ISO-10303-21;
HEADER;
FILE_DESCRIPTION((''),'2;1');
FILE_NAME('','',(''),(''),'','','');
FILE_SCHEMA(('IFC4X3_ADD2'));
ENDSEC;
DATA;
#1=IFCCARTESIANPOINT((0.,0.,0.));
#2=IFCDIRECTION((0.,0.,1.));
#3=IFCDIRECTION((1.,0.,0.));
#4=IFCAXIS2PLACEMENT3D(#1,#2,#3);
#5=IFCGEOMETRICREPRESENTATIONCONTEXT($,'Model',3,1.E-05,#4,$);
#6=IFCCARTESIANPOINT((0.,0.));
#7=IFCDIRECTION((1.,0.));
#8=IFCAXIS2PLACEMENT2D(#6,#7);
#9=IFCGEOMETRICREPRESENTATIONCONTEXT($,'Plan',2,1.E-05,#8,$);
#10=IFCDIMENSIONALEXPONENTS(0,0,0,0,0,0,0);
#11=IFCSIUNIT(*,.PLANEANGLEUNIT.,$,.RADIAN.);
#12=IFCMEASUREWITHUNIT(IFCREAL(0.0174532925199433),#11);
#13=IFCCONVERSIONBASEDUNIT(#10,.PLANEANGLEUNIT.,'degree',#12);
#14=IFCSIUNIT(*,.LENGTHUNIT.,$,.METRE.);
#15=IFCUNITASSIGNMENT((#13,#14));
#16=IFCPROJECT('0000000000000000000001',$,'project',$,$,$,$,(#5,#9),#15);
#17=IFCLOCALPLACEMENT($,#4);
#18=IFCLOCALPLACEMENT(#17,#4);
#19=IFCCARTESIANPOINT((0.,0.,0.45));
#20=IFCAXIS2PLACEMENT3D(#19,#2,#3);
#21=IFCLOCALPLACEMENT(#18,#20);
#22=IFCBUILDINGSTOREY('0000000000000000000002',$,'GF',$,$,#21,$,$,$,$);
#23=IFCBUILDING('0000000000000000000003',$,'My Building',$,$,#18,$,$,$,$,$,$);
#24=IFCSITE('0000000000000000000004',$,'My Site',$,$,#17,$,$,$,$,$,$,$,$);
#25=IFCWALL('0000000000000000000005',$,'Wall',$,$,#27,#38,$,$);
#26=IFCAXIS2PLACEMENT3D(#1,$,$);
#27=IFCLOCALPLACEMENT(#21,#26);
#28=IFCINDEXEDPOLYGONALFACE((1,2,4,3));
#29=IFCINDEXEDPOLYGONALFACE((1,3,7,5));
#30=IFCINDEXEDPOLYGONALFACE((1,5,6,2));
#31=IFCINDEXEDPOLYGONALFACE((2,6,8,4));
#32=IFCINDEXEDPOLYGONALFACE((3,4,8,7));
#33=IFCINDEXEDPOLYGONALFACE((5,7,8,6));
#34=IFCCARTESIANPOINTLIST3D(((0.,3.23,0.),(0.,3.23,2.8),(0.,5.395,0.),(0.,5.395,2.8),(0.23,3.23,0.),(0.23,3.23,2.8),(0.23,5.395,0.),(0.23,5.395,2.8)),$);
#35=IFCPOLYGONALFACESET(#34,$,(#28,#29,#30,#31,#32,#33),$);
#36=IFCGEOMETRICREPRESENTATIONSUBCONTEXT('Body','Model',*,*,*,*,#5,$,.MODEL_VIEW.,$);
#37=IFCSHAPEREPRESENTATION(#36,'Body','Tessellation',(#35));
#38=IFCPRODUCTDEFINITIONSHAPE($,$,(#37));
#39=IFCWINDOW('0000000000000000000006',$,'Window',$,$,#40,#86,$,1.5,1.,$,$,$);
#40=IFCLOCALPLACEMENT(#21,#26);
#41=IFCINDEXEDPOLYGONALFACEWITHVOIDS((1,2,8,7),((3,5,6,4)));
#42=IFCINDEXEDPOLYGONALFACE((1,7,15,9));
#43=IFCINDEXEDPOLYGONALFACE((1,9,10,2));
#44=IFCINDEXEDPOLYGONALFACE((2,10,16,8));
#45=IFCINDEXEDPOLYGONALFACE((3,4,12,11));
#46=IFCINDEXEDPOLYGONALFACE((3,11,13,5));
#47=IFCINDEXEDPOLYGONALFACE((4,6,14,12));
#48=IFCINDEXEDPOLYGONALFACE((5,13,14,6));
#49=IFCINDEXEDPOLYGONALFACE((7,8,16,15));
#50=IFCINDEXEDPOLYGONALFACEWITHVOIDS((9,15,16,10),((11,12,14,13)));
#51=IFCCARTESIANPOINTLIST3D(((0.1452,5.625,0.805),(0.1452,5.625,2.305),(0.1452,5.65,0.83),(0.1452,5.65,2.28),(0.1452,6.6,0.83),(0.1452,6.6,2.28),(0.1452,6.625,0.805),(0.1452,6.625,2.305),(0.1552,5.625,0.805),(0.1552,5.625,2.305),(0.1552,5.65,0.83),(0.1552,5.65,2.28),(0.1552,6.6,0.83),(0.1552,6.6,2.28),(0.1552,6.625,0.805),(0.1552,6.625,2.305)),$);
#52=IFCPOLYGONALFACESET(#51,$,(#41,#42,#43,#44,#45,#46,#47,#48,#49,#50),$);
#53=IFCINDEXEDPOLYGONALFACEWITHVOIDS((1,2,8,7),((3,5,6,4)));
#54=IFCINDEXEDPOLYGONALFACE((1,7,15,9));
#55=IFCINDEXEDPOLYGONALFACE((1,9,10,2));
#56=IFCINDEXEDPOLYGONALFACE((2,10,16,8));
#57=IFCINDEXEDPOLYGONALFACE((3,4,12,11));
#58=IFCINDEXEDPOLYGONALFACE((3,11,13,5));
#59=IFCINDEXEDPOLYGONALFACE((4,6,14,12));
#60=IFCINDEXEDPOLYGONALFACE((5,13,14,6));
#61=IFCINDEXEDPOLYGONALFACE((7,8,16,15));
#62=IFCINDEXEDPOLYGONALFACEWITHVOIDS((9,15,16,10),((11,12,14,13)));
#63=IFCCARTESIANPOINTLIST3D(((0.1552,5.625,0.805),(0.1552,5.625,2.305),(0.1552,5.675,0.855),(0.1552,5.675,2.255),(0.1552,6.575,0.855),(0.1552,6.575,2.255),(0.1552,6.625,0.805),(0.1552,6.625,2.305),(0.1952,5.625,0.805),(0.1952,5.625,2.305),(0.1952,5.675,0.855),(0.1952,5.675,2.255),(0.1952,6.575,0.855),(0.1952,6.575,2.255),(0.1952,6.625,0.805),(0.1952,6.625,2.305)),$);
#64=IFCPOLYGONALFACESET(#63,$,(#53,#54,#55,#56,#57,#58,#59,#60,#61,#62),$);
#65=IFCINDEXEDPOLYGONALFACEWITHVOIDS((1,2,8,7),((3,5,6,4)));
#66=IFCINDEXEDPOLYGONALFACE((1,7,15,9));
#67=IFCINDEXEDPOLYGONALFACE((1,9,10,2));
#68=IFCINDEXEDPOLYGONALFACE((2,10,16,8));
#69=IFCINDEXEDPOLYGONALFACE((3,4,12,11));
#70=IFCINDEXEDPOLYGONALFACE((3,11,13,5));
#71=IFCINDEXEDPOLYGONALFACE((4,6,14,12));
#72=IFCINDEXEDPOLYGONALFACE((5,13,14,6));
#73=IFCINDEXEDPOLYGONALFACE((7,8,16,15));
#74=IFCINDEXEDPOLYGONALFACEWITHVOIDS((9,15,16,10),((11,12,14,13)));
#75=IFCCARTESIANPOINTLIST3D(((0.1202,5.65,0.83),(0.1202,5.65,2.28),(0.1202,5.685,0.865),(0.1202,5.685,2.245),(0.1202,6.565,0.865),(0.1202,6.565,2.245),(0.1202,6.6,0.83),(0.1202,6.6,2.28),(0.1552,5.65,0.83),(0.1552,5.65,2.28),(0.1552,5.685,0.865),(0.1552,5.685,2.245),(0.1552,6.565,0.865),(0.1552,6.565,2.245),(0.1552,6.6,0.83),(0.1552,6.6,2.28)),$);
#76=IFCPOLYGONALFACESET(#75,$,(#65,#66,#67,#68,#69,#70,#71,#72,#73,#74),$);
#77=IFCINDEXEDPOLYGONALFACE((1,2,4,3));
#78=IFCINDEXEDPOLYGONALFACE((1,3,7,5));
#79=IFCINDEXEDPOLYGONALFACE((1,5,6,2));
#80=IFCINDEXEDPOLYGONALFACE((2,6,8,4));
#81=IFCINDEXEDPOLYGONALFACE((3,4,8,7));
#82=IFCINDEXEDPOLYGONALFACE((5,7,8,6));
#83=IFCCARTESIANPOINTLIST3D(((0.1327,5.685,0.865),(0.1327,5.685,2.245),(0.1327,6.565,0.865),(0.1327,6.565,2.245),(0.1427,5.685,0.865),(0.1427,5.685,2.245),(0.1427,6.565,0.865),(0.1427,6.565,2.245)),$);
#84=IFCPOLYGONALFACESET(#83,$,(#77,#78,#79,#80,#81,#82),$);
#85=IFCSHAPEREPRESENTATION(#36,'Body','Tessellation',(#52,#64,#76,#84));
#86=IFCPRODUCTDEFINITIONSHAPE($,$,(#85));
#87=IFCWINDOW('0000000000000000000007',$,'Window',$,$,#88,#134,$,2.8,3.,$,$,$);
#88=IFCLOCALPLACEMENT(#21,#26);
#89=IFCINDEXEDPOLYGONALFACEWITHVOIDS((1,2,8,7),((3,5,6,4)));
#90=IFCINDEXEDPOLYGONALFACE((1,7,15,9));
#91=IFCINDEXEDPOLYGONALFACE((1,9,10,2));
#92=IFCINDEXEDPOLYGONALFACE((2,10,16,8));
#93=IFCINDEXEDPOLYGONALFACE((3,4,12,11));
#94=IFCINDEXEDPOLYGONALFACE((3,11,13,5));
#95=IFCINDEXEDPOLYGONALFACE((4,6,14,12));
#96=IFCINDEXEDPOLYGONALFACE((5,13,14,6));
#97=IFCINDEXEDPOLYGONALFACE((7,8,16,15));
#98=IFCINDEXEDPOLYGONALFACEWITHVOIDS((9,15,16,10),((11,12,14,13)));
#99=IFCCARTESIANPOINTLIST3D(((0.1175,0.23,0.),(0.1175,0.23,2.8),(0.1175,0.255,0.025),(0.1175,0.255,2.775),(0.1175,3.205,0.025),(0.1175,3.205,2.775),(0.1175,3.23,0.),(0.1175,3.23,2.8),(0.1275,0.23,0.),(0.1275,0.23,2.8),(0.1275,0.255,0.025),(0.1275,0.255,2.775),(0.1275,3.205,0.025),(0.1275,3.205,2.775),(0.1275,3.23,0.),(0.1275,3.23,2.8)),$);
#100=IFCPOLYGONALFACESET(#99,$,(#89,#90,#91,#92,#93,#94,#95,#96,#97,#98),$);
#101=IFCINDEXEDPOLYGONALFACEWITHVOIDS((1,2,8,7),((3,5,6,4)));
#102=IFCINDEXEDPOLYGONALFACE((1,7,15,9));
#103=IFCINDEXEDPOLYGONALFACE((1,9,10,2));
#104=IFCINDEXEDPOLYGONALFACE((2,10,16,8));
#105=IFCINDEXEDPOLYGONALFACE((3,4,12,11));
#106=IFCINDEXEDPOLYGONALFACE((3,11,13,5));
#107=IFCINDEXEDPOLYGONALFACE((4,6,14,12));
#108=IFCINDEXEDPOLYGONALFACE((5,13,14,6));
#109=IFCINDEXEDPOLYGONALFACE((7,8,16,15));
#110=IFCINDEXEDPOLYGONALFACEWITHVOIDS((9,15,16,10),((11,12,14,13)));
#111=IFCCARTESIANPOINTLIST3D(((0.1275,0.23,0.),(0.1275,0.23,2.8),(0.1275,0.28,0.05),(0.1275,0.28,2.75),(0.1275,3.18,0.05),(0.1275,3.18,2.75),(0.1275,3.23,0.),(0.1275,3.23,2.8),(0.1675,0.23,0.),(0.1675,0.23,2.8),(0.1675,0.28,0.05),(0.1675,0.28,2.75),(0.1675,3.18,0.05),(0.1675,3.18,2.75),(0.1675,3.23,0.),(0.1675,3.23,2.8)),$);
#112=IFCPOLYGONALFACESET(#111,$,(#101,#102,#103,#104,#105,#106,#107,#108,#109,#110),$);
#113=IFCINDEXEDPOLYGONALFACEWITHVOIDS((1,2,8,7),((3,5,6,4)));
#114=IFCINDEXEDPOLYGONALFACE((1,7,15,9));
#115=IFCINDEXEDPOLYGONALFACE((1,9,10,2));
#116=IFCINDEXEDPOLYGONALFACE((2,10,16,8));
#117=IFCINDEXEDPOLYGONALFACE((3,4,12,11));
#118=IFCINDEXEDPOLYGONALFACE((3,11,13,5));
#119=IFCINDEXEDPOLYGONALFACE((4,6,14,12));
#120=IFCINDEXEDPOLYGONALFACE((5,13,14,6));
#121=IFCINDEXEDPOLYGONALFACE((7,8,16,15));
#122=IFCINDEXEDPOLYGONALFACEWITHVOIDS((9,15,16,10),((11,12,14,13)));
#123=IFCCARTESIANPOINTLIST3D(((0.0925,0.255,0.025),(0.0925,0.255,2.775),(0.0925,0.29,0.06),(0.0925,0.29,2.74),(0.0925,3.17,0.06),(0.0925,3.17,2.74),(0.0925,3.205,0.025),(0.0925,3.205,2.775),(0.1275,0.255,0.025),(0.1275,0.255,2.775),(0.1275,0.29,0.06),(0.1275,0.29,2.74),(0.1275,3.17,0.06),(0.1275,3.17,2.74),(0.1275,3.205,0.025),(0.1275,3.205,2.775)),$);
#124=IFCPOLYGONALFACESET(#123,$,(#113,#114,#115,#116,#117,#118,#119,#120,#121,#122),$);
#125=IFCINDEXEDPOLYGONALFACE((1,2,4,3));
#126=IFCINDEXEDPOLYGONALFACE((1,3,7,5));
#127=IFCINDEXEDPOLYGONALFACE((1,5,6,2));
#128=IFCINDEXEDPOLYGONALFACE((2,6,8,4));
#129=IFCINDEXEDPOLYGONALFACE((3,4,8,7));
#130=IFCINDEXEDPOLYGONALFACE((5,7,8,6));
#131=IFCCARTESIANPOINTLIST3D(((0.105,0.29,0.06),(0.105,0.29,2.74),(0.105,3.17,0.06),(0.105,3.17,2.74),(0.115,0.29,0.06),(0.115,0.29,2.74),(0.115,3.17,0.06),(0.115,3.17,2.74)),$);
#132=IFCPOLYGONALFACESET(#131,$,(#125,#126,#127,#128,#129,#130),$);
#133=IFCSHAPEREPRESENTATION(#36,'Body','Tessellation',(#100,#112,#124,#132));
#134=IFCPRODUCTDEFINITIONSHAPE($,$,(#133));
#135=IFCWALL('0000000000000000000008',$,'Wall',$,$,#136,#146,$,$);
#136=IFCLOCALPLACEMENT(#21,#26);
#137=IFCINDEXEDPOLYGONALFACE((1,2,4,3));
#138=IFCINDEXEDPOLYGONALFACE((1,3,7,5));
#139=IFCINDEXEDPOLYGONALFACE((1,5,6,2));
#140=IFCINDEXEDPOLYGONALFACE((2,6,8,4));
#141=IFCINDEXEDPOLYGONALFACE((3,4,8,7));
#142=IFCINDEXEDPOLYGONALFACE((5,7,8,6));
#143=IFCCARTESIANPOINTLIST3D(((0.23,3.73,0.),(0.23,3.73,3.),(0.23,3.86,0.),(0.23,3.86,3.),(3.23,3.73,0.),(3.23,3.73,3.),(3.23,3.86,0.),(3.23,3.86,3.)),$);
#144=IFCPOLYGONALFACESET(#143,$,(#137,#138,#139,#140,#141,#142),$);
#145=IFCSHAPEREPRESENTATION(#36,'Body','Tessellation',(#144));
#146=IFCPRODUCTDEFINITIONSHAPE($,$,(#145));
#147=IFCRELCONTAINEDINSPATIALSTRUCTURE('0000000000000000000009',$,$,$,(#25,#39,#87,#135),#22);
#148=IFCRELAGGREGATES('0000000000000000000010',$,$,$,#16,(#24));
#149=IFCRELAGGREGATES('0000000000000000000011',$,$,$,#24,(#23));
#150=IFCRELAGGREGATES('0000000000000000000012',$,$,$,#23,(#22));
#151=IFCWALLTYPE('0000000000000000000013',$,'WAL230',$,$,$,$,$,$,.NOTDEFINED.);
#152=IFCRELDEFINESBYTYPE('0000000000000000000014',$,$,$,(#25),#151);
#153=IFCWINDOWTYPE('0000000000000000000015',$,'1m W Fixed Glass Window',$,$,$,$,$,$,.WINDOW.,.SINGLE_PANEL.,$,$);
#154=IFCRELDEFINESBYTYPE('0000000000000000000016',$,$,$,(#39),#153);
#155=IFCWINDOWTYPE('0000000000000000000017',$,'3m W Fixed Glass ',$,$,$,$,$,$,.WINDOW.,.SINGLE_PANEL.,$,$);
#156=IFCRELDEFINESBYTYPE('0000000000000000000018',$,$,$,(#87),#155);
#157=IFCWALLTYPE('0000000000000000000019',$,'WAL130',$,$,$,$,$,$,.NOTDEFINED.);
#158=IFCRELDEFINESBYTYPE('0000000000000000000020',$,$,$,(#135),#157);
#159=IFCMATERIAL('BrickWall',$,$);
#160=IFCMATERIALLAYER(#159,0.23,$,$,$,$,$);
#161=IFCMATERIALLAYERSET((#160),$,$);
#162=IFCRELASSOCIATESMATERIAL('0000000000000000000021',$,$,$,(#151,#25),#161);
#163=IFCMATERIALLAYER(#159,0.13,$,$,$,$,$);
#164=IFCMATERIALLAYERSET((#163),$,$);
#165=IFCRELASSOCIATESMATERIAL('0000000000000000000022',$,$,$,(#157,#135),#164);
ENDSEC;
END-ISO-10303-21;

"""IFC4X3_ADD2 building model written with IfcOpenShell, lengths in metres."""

from ifc_helpers import new_model, entity, si_unit, converted_unit, frame, origin_with_axes, origin_2d_with_axis, place, context, subcontext, project, spatial, line, indexed_curve, outline, extrude, shape, source, transform, mapped, material, layer, layer_set, layer_usage, type_object, type_shapes, element, fill, save


model = new_model("IFC4X3_ADD2")

# Units and contexts
model_context = context("Model", 3, precision=1e-05, world=origin_with_axes())
plan_context = context("Plan", 2, precision=1e-05, world=origin_2d_with_axis())
body_context_1 = subcontext(model_context, "Body", "Model", "MODEL_VIEW")
body_context_2 = subcontext(plan_context, "Body", "Plan", "PLAN_VIEW")
ifc_project = project(units=[converted_unit("PLANEANGLEUNIT", "degree", entity("IfcReal", 0.0174532925199433), si_unit("PLANEANGLEUNIT", "RADIAN"), dimensions=[0, 0, 0, 0, 0, 0, 0]), si_unit("LENGTHUNIT", "METRE")], contexts=[model_context, plan_context])

# Site, building, storey
site_placement = place(None, origin_with_axes())
site = spatial("IfcSite", under=ifc_project, at=site_placement, Name="My Site")
building_placement = place(site_placement, origin_with_axes())
building = spatial("IfcBuilding", under=site, at=building_placement, Name="My Building")
storey_placement = place(building_placement, frame((0.0, 0.0, 0.45), z_axis=(0.0, 0.0, 1.0), x_axis=(1.0, 0.0, 0.0)))
storey = spatial("IfcBuildingStorey", under=building, at=storey_placement, Name="GF")

# Shared definitions
ifc_material_1 = material(Name="BrickWall")

# Shared definitions
ifc_layer_1 = layer(ifc_material_1, 0.23)
ifc_layer_set_1 = layer_set([ifc_layer_1])
wall_type_1 = type_object("IfcWallType", Name="WAL230", PredefinedType="NOTDEFINED", material=ifc_layer_set_1)

# Wall, openings, windows
ifc_layer_usage_1 = layer_usage(ifc_layer_set_1, "AXIS2", "POSITIVE", 0.0)
wall_1_placement = place(storey_placement, frame((0.23, 3.23, 0.0), z_axis=(0.0, 0.0, 1.0), x_axis=(0.0, 1.0, 0.0)))
wall_1 = element("IfcWall", 1, at=wall_1_placement, inside=storey, type_object=wall_type_1, material=ifc_layer_usage_1, Name="Wall", context=body_context_1, shape_type="SweptSolid", body=[
    extrude(outline(indexed_curve([(0.0, 0.0), (0.0, 0.23), (2.165, 0.23), (2.165, 0.0), (0.0, 0.0)], self_intersect=False)), origin_with_axes(), (0.0, 0.0, 1.0), 2.8),
])
shared_shape_1 = source(origin_with_axes(), body_context_1, "Body", "SweptSolid", [
    extrude(outline(indexed_curve([(0.0, 0.0), (1.0, 0.0), (1.0, 1.5), (0.0, 1.5)], segments=[line(1, 2, 3, 4, 1)])), frame((0.0, -0.6, 0.0), z_axis=(0.0, -1.0, 0.0), x_axis=(1.0, 0.0, 0.0)), (0.0, 0.0, -1.0), 1.2),
])
opening_1_placement = place(wall_1_placement, frame((2.395, -0.0152, 0.805), z_axis=(0.0, 0.0, 1.0), x_axis=(1.0, 0.0, 0.0)))
opening_1 = element("IfcOpeningElement", 2, at=opening_1_placement, cuts=wall_1, PredefinedType="OPENING", context=body_context_1, shape_type="MappedRepresentation", body=[
    mapped(shared_shape_1, transform((0.0, 0.0, 0.0), x_axis=(1.0, 0.0, 0.0), y_axis=(0.0, 1.0, 0.0), z_axis=(0.0, 0.0, 1.0), scale=1.0)),
])
shared_shape_2 = source(origin_with_axes(), body_context_1, "Body", "SweptSolid", [
    extrude(outline(indexed_curve([(0.0, 0.0), (3.0, 0.0), (3.0, 2.8), (0.0, 2.8)], segments=[line(1, 2, 3, 4, 1)])), frame((0.0, -0.6, 0.0), z_axis=(0.0, -1.0, 0.0), x_axis=(1.0, 0.0, 0.0)), (0.0, 0.0, -1.0), 1.2),
])
opening_2_placement = place(wall_1_placement, frame((-3.0, 0.0125, 0.0), z_axis=(0.0, 0.0, 1.0), x_axis=(1.0, 0.0, 0.0)))
opening_2 = element("IfcOpeningElement", 3, at=opening_2_placement, cuts=wall_1, PredefinedType="OPENING", context=body_context_1, shape_type="MappedRepresentation", body=[
    mapped(shared_shape_2, transform((0.0, 0.0, 0.0), x_axis=(1.0, 0.0, 0.0), y_axis=(0.0, 1.0, 0.0), z_axis=(0.0, 0.0, 1.0), scale=1.0)),
])
window_type_1 = type_object("IfcWindowType", Name="1m W Fixed Glass Window", PartitioningType="SINGLE_PANEL", PredefinedType="WINDOW")
shared_shape_3 = source(origin_with_axes(), body_context_1, "Body", "SweptSolid", [
    extrude(outline(indexed_curve([(0.0, 0.0), (1.0, 0.0), (1.0, 1.5), (0.0, 1.5)], segments=[line(1, 2, 3, 4, 1)]), holes=[indexed_curve([(0.025, 0.025), (0.975, 0.025), (0.975, 1.475), (0.025, 1.475)], segments=[line(1, 2, 3, 4, 1)])]), frame((0.0, 0.09, 0.0), z_axis=(0.0, -1.0, 0.0), x_axis=(1.0, 0.0, 0.0)), (0.0, 0.0, -1.0), 0.01),
    extrude(outline(indexed_curve([(0.0, 0.0), (1.0, 0.0), (1.0, 1.5), (0.0, 1.5)], segments=[line(1, 2, 3, 4, 1)]), holes=[indexed_curve([(0.05, 0.05), (0.95, 0.05), (0.95, 1.45), (0.05, 1.45)], segments=[line(1, 2, 3, 4, 1)])]), frame((0.0, 0.05, 0.0), z_axis=(0.0, -1.0, 0.0), x_axis=(1.0, 0.0, 0.0)), (0.0, 0.0, -1.0), 0.04),
    extrude(outline(indexed_curve([(0.0, 0.0), (0.95, 0.0), (0.95, 1.45), (0.0, 1.45)], segments=[line(1, 2, 3, 4, 1)]), holes=[indexed_curve([(0.035, 0.035), (0.915, 0.035), (0.915, 1.415), (0.035, 1.415)], segments=[line(1, 2, 3, 4, 1)])]), frame((0.025, 0.09, 0.025), z_axis=(0.0, -1.0, 0.0), x_axis=(1.0, 0.0, 0.0)), (0.0, 0.0, -1.0), 0.035),
    extrude(outline(indexed_curve([(0.035, 0.035), (0.915, 0.035), (0.915, 1.415), (0.035, 1.415)], segments=[line(1, 2, 3, 4, 1)])), frame((0.025, 0.1025, 0.025), z_axis=(0.0, -1.0, 0.0), x_axis=(1.0, 0.0, 0.0)), (0.0, 0.0, -1.0), 0.01),
])
shared_shape_4 = source(origin_with_axes(), body_context_2, "Body", "Curve2D", [
    entity("IfcIndexedPolyCurve", entity("IfcCartesianPointList2D", [[0.05, 0.05], [0.95, 0.05]])),
    entity("IfcIndexedPolyCurve", entity("IfcCartesianPointList2D", [[0.0, 0.1], [0.025, 0.1], [0.025, 0.09], [0.05, 0.09], [0.05, 0.05], [0.0, 0.05]]), [entity("IfcLineIndex", [1, 2, 3, 4, 5, 6, 1])]),
    entity("IfcIndexedPolyCurve", entity("IfcCartesianPointList2D", [[1.0, 0.1], [0.975, 0.1], [0.975, 0.09], [0.95, 0.09], [0.95, 0.05], [1.0, 0.05]]), [entity("IfcLineIndex", [1, 2, 3, 4, 5, 6, 1])]),
    entity("IfcIndexedPolyCurve", entity("IfcCartesianPointList2D", [[0.025, 0.09], [0.06, 0.09], [0.06, 0.125], [0.025, 0.125]]), [entity("IfcLineIndex", [1, 2, 3, 4, 1])]),
    entity("IfcIndexedPolyCurve", entity("IfcCartesianPointList2D", [[0.975, 0.09], [0.94, 0.09], [0.94, 0.125], [0.975, 0.125]]), [entity("IfcLineIndex", [1, 2, 3, 4, 1])]),
    entity("IfcIndexedPolyCurve", entity("IfcCartesianPointList2D", [[0.06, 0.09], [0.94, 0.09]])),
    entity("IfcIndexedPolyCurve", entity("IfcCartesianPointList2D", [[0.06, 0.125], [0.94, 0.125]])),
    entity("IfcIndexedPolyCurve", entity("IfcCartesianPointList2D", [[0.06, 0.1075], [0.94, 0.1075]])),
])
type_shapes(window_type_1, [shared_shape_3, shared_shape_4])
window_1_placement = place(opening_1_placement, origin_with_axes())
window_1 = element("IfcWindow", 4, at=window_1_placement, inside=storey, type_object=window_type_1, Name="Window", OverallHeight=1.5, OverallWidth=1.0, shapes=[
    shape(body_context_1, "Body", "MappedRepresentation", [mapped(shared_shape_3, transform((0.0, 0.0, 0.0), x_axis=(1.0, 0.0, 0.0), y_axis=(0.0, 1.0, 0.0), z_axis=(0.0, 0.0, 1.0), scale=1.0))]),
    shape(body_context_2, "Body", "MappedRepresentation", [mapped(shared_shape_4, transform((0.0, 0.0, 0.0), x_axis=(1.0, 0.0, 0.0), y_axis=(0.0, 1.0, 0.0), z_axis=(0.0, 0.0, 1.0), scale=1.0))]),
])
fill(opening_1, window_1)
window_type_2 = type_object("IfcWindowType", Name="3m W Fixed Glass ", PartitioningType="SINGLE_PANEL", PredefinedType="WINDOW")
shared_shape_5 = source(origin_with_axes(), body_context_1, "Body", "SweptSolid", [
    extrude(outline(indexed_curve([(0.0, 0.0), (3.0, 0.0), (3.0, 2.8), (0.0, 2.8)], segments=[line(1, 2, 3, 4, 1)]), holes=[indexed_curve([(0.025, 0.025), (2.975, 0.025), (2.975, 2.775), (0.025, 2.775)], segments=[line(1, 2, 3, 4, 1)])]), frame((0.0, 0.09, 0.0), z_axis=(0.0, -1.0, 0.0), x_axis=(1.0, 0.0, 0.0)), (0.0, 0.0, -1.0), 0.01),
    extrude(outline(indexed_curve([(0.0, 0.0), (3.0, 0.0), (3.0, 2.8), (0.0, 2.8)], segments=[line(1, 2, 3, 4, 1)]), holes=[indexed_curve([(0.05, 0.05), (2.95, 0.05), (2.95, 2.75), (0.05, 2.75)], segments=[line(1, 2, 3, 4, 1)])]), frame((0.0, 0.05, 0.0), z_axis=(0.0, -1.0, 0.0), x_axis=(1.0, 0.0, 0.0)), (0.0, 0.0, -1.0), 0.04),
    extrude(outline(indexed_curve([(0.0, 0.0), (2.95, 0.0), (2.95, 2.75), (0.0, 2.75)], segments=[line(1, 2, 3, 4, 1)]), holes=[indexed_curve([(0.035, 0.035), (2.915, 0.035), (2.915, 2.715), (0.035, 2.715)], segments=[line(1, 2, 3, 4, 1)])]), frame((0.025, 0.09, 0.025), z_axis=(0.0, -1.0, 0.0), x_axis=(1.0, 0.0, 0.0)), (0.0, 0.0, -1.0), 0.035),
    extrude(outline(indexed_curve([(0.035, 0.035), (2.915, 0.035), (2.915, 2.715), (0.035, 2.715)], segments=[line(1, 2, 3, 4, 1)])), frame((0.025, 0.1025, 0.025), z_axis=(0.0, -1.0, 0.0), x_axis=(1.0, 0.0, 0.0)), (0.0, 0.0, -1.0), 0.01),
])
shared_shape_6 = source(origin_with_axes(), body_context_2, "Body", "Curve2D", [
    entity("IfcIndexedPolyCurve", entity("IfcCartesianPointList2D", [[0.05, 0.05], [2.95, 0.05]])),
    entity("IfcIndexedPolyCurve", entity("IfcCartesianPointList2D", [[0.0, 0.1], [0.025, 0.1], [0.025, 0.09], [0.05, 0.09], [0.05, 0.05], [0.0, 0.05]]), [entity("IfcLineIndex", [1, 2, 3, 4, 5, 6, 1])]),
    entity("IfcIndexedPolyCurve", entity("IfcCartesianPointList2D", [[3.0, 0.1], [2.975, 0.1], [2.975, 0.09], [2.95, 0.09], [2.95, 0.05], [3.0, 0.05]]), [entity("IfcLineIndex", [1, 2, 3, 4, 5, 6, 1])]),
    entity("IfcIndexedPolyCurve", entity("IfcCartesianPointList2D", [[0.025, 0.09], [0.06, 0.09], [0.06, 0.125], [0.025, 0.125]]), [entity("IfcLineIndex", [1, 2, 3, 4, 1])]),
    entity("IfcIndexedPolyCurve", entity("IfcCartesianPointList2D", [[2.975, 0.09], [2.94, 0.09], [2.94, 0.125], [2.975, 0.125]]), [entity("IfcLineIndex", [1, 2, 3, 4, 1])]),
    entity("IfcIndexedPolyCurve", entity("IfcCartesianPointList2D", [[0.06, 0.09], [2.94, 0.09]])),
    entity("IfcIndexedPolyCurve", entity("IfcCartesianPointList2D", [[0.06, 0.125], [2.94, 0.125]])),
    entity("IfcIndexedPolyCurve", entity("IfcCartesianPointList2D", [[0.06, 0.1075], [2.94, 0.1075]])),
])
type_shapes(window_type_2, [shared_shape_5, shared_shape_6])
window_2_placement = place(opening_2_placement, frame((0.0, 0.0, 0.0), z_axis=(0.0, 0.0, 1.0), x_axis=(1.0, 0.0, 0.0)))
window_2 = element("IfcWindow", 5, at=window_2_placement, inside=storey, type_object=window_type_2, Name="Window", OverallHeight=2.8, OverallWidth=3.0, shapes=[
    shape(body_context_1, "Body", "MappedRepresentation", [mapped(shared_shape_5, transform((0.0, 0.0, 0.0), x_axis=(1.0, 0.0, 0.0), y_axis=(0.0, 1.0, 0.0), z_axis=(0.0, 0.0, 1.0), scale=1.0))]),
    shape(body_context_2, "Body", "MappedRepresentation", [mapped(shared_shape_6, transform((0.0, 0.0, 0.0), x_axis=(1.0, 0.0, 0.0), y_axis=(0.0, 1.0, 0.0), z_axis=(0.0, 0.0, 1.0), scale=1.0))]),
])
fill(opening_2, window_2)

# Wall
ifc_layer_2 = layer(ifc_material_1, 0.13)
ifc_layer_set_2 = layer_set([ifc_layer_2])
ifc_layer_usage_2 = layer_usage(ifc_layer_set_2, "AXIS2", "POSITIVE", 0.0)
wall_type_2 = type_object("IfcWallType", Name="WAL130", PredefinedType="NOTDEFINED", material=ifc_layer_set_2)
wall_2_placement = place(storey_placement, frame((0.23, 3.73, 0.0), z_axis=(0.0, 0.0, 1.0), x_axis=(1.0, 0.0, 0.0)))
element("IfcWall", 6, at=wall_2_placement, inside=storey, type_object=wall_type_2, material=ifc_layer_usage_2, Name="Wall", context=body_context_1, shape_type="SweptSolid", body=[
    extrude(outline(indexed_curve([(0.0, 0.0), (0.0, 0.13), (3.0, 0.13), (3.0, 0.0), (0.0, 0.0)], self_intersect=False)), origin_with_axes(), (0.0, 0.0, 1.0), 3.0),
])

save(model, "model.ifc")
